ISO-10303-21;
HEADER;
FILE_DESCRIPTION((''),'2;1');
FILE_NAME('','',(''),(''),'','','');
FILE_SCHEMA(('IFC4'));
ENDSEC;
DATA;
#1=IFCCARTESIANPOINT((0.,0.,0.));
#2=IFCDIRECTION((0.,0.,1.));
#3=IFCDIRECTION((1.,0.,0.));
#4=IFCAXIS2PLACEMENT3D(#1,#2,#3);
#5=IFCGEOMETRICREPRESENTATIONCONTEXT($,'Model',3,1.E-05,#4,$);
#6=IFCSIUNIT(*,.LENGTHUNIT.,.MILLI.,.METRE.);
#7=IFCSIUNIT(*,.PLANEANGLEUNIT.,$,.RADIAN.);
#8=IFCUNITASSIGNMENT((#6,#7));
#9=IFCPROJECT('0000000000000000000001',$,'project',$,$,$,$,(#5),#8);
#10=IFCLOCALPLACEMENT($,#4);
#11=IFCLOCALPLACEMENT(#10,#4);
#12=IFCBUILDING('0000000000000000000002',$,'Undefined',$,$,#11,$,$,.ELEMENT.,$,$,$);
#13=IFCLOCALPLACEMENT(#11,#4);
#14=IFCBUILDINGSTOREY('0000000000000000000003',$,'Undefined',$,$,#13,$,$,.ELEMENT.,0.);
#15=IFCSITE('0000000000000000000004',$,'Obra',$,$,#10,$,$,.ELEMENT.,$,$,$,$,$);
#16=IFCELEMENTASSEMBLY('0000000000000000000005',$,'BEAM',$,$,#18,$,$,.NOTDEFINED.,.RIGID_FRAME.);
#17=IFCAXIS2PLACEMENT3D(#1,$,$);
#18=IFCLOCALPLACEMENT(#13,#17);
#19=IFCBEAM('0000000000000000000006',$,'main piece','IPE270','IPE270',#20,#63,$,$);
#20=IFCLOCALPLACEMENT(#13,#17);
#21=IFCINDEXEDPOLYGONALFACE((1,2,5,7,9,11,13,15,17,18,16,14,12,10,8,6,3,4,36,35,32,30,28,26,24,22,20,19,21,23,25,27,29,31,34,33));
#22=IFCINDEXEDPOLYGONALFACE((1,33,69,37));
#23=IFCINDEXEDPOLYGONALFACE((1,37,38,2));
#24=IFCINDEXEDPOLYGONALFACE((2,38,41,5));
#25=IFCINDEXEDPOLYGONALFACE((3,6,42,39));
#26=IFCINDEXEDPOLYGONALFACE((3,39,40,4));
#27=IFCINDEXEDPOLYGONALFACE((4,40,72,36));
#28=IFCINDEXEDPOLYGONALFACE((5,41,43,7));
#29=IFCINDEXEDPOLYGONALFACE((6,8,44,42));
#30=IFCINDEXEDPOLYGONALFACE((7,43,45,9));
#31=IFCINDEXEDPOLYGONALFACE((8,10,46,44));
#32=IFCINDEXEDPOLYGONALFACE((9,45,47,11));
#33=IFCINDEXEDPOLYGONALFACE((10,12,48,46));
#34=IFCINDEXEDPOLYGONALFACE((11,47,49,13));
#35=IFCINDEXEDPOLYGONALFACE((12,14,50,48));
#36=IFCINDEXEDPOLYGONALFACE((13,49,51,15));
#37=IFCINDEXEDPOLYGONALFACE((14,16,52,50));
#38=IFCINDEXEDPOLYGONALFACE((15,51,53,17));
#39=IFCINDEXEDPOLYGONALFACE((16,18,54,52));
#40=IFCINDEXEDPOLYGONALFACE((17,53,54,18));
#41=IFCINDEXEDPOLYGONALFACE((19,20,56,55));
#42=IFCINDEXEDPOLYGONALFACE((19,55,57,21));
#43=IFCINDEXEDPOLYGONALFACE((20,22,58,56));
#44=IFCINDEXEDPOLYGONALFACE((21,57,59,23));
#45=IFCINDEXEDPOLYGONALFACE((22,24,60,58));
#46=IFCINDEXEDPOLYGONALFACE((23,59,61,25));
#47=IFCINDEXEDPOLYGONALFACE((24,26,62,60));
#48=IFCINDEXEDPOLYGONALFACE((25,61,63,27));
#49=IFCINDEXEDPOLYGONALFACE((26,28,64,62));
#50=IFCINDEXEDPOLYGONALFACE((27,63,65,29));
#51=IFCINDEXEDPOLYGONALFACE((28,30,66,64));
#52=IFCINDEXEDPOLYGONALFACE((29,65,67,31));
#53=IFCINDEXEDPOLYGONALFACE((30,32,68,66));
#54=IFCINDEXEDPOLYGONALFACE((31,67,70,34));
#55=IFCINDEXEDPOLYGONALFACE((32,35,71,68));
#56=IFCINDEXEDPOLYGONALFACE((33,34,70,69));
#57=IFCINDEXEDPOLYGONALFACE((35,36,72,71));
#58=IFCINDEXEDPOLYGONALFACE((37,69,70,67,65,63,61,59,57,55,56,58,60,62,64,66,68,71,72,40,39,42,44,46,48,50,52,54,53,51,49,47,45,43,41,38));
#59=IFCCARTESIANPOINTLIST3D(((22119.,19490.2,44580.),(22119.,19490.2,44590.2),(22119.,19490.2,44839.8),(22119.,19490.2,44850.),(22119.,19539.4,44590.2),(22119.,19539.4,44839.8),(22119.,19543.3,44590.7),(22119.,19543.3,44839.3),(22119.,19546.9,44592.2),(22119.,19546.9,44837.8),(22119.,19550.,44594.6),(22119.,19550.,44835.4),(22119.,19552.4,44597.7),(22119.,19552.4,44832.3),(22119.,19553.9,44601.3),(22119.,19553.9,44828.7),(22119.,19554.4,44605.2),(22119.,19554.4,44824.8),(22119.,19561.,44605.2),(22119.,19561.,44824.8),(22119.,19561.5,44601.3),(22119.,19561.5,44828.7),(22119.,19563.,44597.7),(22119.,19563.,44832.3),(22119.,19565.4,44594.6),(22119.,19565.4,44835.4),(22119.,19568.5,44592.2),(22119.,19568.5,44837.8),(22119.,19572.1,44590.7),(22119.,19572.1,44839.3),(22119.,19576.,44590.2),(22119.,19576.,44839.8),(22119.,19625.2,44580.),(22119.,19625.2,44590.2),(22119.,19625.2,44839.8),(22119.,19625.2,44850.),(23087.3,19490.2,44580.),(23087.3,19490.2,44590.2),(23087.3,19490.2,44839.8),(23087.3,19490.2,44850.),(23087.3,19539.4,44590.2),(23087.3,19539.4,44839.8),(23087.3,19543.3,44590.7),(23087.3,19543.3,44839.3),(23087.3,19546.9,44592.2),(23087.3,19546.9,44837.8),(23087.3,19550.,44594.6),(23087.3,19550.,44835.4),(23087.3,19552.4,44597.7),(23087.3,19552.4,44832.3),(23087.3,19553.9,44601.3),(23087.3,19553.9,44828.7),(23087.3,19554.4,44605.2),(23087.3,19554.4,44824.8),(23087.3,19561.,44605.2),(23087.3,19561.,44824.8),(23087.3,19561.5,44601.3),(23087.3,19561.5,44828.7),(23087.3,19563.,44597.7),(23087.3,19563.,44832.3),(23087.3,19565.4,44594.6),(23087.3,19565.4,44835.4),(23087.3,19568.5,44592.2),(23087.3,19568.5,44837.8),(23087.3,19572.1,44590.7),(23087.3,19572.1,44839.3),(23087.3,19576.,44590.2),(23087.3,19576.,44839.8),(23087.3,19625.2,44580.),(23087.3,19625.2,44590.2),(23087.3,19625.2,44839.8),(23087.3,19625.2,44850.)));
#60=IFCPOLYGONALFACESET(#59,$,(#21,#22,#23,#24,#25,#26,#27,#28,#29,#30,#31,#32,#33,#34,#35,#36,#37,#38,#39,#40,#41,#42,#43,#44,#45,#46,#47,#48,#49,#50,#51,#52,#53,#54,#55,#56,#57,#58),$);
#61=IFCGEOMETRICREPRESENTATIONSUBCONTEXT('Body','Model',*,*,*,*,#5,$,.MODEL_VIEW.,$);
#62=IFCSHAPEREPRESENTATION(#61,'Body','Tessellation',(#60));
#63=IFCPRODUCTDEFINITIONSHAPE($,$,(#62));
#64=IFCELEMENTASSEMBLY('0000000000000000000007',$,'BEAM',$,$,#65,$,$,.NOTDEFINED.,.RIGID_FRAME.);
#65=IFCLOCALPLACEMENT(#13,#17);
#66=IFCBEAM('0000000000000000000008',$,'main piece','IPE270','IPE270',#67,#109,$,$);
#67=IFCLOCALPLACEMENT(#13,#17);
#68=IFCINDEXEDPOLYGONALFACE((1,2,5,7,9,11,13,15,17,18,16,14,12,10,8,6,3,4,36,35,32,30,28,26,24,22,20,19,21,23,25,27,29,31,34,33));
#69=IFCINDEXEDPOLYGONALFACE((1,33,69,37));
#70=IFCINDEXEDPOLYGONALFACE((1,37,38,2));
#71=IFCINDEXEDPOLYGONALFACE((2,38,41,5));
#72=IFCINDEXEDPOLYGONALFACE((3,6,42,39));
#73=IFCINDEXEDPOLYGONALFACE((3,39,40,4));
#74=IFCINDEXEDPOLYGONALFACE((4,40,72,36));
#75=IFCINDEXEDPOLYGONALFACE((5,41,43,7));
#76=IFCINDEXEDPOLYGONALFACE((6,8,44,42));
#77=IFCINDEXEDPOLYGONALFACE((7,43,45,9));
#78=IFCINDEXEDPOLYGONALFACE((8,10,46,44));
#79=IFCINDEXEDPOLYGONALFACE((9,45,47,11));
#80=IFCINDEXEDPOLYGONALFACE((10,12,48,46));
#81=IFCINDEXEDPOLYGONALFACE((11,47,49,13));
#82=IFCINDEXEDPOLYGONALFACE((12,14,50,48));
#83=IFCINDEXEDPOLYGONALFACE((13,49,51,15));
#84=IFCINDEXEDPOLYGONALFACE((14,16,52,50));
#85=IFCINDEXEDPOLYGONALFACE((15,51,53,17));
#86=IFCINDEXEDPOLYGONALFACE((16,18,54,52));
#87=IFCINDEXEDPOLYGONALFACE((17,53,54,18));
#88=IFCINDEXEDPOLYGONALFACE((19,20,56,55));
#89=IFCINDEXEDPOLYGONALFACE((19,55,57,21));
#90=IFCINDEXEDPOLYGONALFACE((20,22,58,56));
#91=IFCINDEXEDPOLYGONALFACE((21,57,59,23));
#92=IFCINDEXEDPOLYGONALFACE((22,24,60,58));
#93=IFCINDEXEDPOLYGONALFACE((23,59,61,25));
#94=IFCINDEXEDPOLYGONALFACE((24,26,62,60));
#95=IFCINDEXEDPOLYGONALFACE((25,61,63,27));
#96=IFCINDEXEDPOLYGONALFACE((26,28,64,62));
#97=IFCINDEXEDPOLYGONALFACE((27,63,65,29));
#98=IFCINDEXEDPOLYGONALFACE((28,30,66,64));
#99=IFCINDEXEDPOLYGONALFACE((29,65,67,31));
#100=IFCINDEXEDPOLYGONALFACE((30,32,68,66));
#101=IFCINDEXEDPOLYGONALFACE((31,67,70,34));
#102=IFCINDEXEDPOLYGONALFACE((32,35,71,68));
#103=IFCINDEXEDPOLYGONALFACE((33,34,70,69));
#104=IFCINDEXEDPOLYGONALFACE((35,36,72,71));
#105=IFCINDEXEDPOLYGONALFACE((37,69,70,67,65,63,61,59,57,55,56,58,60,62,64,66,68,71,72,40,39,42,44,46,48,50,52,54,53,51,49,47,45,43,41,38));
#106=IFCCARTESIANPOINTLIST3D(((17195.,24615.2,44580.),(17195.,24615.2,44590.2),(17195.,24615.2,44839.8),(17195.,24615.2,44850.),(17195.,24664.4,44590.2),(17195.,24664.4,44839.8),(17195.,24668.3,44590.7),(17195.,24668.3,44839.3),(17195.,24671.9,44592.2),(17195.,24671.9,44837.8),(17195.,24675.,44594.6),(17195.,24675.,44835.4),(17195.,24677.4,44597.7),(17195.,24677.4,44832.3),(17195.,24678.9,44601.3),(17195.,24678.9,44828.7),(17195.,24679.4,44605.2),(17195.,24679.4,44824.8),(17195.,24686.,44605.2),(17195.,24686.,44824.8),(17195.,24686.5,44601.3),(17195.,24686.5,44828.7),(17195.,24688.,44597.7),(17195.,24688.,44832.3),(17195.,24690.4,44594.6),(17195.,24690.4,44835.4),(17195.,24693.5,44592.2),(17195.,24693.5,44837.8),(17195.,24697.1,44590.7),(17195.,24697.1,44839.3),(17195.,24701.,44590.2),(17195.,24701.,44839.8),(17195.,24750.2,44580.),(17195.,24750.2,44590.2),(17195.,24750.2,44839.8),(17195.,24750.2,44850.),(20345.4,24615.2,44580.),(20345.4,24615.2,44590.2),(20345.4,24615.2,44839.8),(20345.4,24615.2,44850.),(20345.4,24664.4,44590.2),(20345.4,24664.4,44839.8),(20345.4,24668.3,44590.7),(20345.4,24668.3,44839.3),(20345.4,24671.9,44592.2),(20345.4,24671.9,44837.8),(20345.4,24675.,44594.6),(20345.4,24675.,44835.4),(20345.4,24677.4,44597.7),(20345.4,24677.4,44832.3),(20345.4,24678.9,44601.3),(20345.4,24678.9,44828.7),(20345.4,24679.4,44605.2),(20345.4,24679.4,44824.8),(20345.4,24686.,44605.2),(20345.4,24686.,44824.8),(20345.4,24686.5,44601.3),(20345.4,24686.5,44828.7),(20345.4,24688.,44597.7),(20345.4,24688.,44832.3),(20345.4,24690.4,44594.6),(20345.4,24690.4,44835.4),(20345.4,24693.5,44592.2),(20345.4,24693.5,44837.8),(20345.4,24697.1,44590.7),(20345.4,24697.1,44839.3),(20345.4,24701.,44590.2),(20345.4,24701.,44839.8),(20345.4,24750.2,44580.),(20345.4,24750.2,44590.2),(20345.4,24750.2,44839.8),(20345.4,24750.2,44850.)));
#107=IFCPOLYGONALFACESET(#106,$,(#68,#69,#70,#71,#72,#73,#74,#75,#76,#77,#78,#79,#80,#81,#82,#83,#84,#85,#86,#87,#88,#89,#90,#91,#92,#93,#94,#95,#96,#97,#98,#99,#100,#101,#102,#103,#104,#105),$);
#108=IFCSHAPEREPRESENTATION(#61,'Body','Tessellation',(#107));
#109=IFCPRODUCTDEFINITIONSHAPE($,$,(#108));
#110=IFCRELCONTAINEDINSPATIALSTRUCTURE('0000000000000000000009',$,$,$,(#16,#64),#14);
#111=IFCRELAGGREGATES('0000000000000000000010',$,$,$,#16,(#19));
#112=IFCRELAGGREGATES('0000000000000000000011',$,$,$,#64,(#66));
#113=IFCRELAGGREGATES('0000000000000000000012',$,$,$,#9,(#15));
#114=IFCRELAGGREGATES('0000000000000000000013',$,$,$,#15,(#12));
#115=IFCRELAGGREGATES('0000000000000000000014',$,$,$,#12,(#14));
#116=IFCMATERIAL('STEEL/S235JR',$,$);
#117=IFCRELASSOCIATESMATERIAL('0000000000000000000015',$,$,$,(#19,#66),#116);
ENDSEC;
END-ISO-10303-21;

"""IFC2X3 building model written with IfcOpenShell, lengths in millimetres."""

from ifc_helpers import new_model, si_unit, frame, origin_with_axes, origin_2d_with_axis, place, context, subcontext, project, spatial, i_section, extrude, material, element, aggregate, save


model = new_model("IFC2X3")

# Units and contexts
model_context = context("Model", 3, precision=1e-05, world=origin_with_axes())
body_context = subcontext(model_context, "Body", "Model", "MODEL_VIEW")
ifc_project = project(units=[si_unit("LENGTHUNIT", "METRE", prefix="MILLI"), si_unit("PLANEANGLEUNIT", "RADIAN")], contexts=[model_context])

# Site, building, storey
site_placement = place(None, origin_with_axes())
site = spatial("IfcSite", under=ifc_project, at=site_placement, Name="Obra", CompositionType="ELEMENT")
building_placement = place(site_placement, origin_with_axes())
building = spatial("IfcBuilding", under=site, at=building_placement, Name="Undefined", CompositionType="ELEMENT")
storey_placement = place(building_placement, origin_with_axes())
storey = spatial("IfcBuildingStorey", under=building, at=storey_placement, Name="Undefined", CompositionType="ELEMENT", Elevation=0.0)

# Shared definitions
ifc_material_1 = material(Name="STEEL/S235JR")

# Element assemblies, beams
assembly_1_placement = place(storey_placement, origin_with_axes())
assembly_1 = element("IfcElementAssembly", 1, at=assembly_1_placement, inside=storey, Name="BEAM", AssemblyPlace="NOTDEFINED", PredefinedType="RIGID_FRAME")
beam_1_placement = place(assembly_1_placement, frame((22119.0, 19557.7, 44715.0), z_axis=(0.0, 0.0, 1.0), x_axis=(1.0, 0.0, 0.0)))
beam_1 = element("IfcBeam", 2, at=beam_1_placement, material=ifc_material_1, Name="main piece", Description="IPE270", ObjectType="IPE270", context=body_context, shape_type="SweptSolid", body=[
    extrude(i_section(OverallWidth=135.0, OverallDepth=270.0, WebThickness=6.6, FlangeThickness=10.2, FilletRadius=15.0, at=origin_2d_with_axis()), frame((968.2, 0.0, 0.0), z_axis=(-1.0, 0.0, 0.0), x_axis=(0.0, -1.0, 0.0)), (0.0, 0.0, 1.0), 968.2),
])
aggregate(assembly_1, [beam_1])
assembly_2_placement = place(storey_placement, origin_with_axes())
assembly_2 = element("IfcElementAssembly", 3, at=assembly_2_placement, inside=storey, Name="BEAM", AssemblyPlace="NOTDEFINED", PredefinedType="RIGID_FRAME")
beam_2_placement = place(assembly_2_placement, frame((17195.0, 24682.7, 44715.0), z_axis=(0.0, 0.0, 1.0), x_axis=(1.0, 0.0, 0.0)))
beam_2 = element("IfcBeam", 4, at=beam_2_placement, material=ifc_material_1, Name="main piece", Description="IPE270", ObjectType="IPE270", context=body_context, shape_type="SweptSolid", body=[
    extrude(i_section(OverallWidth=135.0, OverallDepth=270.0, WebThickness=6.6, FlangeThickness=10.2, FilletRadius=15.0, at=origin_2d_with_axis()), frame((3150.4, 0.0, 0.0), z_axis=(-1.0, 0.0, 0.0), x_axis=(0.0, -1.0, 0.0)), (0.0, 0.0, 1.0), 3150.4),
])
aggregate(assembly_2, [beam_2])

save(model, "model.ifc")
